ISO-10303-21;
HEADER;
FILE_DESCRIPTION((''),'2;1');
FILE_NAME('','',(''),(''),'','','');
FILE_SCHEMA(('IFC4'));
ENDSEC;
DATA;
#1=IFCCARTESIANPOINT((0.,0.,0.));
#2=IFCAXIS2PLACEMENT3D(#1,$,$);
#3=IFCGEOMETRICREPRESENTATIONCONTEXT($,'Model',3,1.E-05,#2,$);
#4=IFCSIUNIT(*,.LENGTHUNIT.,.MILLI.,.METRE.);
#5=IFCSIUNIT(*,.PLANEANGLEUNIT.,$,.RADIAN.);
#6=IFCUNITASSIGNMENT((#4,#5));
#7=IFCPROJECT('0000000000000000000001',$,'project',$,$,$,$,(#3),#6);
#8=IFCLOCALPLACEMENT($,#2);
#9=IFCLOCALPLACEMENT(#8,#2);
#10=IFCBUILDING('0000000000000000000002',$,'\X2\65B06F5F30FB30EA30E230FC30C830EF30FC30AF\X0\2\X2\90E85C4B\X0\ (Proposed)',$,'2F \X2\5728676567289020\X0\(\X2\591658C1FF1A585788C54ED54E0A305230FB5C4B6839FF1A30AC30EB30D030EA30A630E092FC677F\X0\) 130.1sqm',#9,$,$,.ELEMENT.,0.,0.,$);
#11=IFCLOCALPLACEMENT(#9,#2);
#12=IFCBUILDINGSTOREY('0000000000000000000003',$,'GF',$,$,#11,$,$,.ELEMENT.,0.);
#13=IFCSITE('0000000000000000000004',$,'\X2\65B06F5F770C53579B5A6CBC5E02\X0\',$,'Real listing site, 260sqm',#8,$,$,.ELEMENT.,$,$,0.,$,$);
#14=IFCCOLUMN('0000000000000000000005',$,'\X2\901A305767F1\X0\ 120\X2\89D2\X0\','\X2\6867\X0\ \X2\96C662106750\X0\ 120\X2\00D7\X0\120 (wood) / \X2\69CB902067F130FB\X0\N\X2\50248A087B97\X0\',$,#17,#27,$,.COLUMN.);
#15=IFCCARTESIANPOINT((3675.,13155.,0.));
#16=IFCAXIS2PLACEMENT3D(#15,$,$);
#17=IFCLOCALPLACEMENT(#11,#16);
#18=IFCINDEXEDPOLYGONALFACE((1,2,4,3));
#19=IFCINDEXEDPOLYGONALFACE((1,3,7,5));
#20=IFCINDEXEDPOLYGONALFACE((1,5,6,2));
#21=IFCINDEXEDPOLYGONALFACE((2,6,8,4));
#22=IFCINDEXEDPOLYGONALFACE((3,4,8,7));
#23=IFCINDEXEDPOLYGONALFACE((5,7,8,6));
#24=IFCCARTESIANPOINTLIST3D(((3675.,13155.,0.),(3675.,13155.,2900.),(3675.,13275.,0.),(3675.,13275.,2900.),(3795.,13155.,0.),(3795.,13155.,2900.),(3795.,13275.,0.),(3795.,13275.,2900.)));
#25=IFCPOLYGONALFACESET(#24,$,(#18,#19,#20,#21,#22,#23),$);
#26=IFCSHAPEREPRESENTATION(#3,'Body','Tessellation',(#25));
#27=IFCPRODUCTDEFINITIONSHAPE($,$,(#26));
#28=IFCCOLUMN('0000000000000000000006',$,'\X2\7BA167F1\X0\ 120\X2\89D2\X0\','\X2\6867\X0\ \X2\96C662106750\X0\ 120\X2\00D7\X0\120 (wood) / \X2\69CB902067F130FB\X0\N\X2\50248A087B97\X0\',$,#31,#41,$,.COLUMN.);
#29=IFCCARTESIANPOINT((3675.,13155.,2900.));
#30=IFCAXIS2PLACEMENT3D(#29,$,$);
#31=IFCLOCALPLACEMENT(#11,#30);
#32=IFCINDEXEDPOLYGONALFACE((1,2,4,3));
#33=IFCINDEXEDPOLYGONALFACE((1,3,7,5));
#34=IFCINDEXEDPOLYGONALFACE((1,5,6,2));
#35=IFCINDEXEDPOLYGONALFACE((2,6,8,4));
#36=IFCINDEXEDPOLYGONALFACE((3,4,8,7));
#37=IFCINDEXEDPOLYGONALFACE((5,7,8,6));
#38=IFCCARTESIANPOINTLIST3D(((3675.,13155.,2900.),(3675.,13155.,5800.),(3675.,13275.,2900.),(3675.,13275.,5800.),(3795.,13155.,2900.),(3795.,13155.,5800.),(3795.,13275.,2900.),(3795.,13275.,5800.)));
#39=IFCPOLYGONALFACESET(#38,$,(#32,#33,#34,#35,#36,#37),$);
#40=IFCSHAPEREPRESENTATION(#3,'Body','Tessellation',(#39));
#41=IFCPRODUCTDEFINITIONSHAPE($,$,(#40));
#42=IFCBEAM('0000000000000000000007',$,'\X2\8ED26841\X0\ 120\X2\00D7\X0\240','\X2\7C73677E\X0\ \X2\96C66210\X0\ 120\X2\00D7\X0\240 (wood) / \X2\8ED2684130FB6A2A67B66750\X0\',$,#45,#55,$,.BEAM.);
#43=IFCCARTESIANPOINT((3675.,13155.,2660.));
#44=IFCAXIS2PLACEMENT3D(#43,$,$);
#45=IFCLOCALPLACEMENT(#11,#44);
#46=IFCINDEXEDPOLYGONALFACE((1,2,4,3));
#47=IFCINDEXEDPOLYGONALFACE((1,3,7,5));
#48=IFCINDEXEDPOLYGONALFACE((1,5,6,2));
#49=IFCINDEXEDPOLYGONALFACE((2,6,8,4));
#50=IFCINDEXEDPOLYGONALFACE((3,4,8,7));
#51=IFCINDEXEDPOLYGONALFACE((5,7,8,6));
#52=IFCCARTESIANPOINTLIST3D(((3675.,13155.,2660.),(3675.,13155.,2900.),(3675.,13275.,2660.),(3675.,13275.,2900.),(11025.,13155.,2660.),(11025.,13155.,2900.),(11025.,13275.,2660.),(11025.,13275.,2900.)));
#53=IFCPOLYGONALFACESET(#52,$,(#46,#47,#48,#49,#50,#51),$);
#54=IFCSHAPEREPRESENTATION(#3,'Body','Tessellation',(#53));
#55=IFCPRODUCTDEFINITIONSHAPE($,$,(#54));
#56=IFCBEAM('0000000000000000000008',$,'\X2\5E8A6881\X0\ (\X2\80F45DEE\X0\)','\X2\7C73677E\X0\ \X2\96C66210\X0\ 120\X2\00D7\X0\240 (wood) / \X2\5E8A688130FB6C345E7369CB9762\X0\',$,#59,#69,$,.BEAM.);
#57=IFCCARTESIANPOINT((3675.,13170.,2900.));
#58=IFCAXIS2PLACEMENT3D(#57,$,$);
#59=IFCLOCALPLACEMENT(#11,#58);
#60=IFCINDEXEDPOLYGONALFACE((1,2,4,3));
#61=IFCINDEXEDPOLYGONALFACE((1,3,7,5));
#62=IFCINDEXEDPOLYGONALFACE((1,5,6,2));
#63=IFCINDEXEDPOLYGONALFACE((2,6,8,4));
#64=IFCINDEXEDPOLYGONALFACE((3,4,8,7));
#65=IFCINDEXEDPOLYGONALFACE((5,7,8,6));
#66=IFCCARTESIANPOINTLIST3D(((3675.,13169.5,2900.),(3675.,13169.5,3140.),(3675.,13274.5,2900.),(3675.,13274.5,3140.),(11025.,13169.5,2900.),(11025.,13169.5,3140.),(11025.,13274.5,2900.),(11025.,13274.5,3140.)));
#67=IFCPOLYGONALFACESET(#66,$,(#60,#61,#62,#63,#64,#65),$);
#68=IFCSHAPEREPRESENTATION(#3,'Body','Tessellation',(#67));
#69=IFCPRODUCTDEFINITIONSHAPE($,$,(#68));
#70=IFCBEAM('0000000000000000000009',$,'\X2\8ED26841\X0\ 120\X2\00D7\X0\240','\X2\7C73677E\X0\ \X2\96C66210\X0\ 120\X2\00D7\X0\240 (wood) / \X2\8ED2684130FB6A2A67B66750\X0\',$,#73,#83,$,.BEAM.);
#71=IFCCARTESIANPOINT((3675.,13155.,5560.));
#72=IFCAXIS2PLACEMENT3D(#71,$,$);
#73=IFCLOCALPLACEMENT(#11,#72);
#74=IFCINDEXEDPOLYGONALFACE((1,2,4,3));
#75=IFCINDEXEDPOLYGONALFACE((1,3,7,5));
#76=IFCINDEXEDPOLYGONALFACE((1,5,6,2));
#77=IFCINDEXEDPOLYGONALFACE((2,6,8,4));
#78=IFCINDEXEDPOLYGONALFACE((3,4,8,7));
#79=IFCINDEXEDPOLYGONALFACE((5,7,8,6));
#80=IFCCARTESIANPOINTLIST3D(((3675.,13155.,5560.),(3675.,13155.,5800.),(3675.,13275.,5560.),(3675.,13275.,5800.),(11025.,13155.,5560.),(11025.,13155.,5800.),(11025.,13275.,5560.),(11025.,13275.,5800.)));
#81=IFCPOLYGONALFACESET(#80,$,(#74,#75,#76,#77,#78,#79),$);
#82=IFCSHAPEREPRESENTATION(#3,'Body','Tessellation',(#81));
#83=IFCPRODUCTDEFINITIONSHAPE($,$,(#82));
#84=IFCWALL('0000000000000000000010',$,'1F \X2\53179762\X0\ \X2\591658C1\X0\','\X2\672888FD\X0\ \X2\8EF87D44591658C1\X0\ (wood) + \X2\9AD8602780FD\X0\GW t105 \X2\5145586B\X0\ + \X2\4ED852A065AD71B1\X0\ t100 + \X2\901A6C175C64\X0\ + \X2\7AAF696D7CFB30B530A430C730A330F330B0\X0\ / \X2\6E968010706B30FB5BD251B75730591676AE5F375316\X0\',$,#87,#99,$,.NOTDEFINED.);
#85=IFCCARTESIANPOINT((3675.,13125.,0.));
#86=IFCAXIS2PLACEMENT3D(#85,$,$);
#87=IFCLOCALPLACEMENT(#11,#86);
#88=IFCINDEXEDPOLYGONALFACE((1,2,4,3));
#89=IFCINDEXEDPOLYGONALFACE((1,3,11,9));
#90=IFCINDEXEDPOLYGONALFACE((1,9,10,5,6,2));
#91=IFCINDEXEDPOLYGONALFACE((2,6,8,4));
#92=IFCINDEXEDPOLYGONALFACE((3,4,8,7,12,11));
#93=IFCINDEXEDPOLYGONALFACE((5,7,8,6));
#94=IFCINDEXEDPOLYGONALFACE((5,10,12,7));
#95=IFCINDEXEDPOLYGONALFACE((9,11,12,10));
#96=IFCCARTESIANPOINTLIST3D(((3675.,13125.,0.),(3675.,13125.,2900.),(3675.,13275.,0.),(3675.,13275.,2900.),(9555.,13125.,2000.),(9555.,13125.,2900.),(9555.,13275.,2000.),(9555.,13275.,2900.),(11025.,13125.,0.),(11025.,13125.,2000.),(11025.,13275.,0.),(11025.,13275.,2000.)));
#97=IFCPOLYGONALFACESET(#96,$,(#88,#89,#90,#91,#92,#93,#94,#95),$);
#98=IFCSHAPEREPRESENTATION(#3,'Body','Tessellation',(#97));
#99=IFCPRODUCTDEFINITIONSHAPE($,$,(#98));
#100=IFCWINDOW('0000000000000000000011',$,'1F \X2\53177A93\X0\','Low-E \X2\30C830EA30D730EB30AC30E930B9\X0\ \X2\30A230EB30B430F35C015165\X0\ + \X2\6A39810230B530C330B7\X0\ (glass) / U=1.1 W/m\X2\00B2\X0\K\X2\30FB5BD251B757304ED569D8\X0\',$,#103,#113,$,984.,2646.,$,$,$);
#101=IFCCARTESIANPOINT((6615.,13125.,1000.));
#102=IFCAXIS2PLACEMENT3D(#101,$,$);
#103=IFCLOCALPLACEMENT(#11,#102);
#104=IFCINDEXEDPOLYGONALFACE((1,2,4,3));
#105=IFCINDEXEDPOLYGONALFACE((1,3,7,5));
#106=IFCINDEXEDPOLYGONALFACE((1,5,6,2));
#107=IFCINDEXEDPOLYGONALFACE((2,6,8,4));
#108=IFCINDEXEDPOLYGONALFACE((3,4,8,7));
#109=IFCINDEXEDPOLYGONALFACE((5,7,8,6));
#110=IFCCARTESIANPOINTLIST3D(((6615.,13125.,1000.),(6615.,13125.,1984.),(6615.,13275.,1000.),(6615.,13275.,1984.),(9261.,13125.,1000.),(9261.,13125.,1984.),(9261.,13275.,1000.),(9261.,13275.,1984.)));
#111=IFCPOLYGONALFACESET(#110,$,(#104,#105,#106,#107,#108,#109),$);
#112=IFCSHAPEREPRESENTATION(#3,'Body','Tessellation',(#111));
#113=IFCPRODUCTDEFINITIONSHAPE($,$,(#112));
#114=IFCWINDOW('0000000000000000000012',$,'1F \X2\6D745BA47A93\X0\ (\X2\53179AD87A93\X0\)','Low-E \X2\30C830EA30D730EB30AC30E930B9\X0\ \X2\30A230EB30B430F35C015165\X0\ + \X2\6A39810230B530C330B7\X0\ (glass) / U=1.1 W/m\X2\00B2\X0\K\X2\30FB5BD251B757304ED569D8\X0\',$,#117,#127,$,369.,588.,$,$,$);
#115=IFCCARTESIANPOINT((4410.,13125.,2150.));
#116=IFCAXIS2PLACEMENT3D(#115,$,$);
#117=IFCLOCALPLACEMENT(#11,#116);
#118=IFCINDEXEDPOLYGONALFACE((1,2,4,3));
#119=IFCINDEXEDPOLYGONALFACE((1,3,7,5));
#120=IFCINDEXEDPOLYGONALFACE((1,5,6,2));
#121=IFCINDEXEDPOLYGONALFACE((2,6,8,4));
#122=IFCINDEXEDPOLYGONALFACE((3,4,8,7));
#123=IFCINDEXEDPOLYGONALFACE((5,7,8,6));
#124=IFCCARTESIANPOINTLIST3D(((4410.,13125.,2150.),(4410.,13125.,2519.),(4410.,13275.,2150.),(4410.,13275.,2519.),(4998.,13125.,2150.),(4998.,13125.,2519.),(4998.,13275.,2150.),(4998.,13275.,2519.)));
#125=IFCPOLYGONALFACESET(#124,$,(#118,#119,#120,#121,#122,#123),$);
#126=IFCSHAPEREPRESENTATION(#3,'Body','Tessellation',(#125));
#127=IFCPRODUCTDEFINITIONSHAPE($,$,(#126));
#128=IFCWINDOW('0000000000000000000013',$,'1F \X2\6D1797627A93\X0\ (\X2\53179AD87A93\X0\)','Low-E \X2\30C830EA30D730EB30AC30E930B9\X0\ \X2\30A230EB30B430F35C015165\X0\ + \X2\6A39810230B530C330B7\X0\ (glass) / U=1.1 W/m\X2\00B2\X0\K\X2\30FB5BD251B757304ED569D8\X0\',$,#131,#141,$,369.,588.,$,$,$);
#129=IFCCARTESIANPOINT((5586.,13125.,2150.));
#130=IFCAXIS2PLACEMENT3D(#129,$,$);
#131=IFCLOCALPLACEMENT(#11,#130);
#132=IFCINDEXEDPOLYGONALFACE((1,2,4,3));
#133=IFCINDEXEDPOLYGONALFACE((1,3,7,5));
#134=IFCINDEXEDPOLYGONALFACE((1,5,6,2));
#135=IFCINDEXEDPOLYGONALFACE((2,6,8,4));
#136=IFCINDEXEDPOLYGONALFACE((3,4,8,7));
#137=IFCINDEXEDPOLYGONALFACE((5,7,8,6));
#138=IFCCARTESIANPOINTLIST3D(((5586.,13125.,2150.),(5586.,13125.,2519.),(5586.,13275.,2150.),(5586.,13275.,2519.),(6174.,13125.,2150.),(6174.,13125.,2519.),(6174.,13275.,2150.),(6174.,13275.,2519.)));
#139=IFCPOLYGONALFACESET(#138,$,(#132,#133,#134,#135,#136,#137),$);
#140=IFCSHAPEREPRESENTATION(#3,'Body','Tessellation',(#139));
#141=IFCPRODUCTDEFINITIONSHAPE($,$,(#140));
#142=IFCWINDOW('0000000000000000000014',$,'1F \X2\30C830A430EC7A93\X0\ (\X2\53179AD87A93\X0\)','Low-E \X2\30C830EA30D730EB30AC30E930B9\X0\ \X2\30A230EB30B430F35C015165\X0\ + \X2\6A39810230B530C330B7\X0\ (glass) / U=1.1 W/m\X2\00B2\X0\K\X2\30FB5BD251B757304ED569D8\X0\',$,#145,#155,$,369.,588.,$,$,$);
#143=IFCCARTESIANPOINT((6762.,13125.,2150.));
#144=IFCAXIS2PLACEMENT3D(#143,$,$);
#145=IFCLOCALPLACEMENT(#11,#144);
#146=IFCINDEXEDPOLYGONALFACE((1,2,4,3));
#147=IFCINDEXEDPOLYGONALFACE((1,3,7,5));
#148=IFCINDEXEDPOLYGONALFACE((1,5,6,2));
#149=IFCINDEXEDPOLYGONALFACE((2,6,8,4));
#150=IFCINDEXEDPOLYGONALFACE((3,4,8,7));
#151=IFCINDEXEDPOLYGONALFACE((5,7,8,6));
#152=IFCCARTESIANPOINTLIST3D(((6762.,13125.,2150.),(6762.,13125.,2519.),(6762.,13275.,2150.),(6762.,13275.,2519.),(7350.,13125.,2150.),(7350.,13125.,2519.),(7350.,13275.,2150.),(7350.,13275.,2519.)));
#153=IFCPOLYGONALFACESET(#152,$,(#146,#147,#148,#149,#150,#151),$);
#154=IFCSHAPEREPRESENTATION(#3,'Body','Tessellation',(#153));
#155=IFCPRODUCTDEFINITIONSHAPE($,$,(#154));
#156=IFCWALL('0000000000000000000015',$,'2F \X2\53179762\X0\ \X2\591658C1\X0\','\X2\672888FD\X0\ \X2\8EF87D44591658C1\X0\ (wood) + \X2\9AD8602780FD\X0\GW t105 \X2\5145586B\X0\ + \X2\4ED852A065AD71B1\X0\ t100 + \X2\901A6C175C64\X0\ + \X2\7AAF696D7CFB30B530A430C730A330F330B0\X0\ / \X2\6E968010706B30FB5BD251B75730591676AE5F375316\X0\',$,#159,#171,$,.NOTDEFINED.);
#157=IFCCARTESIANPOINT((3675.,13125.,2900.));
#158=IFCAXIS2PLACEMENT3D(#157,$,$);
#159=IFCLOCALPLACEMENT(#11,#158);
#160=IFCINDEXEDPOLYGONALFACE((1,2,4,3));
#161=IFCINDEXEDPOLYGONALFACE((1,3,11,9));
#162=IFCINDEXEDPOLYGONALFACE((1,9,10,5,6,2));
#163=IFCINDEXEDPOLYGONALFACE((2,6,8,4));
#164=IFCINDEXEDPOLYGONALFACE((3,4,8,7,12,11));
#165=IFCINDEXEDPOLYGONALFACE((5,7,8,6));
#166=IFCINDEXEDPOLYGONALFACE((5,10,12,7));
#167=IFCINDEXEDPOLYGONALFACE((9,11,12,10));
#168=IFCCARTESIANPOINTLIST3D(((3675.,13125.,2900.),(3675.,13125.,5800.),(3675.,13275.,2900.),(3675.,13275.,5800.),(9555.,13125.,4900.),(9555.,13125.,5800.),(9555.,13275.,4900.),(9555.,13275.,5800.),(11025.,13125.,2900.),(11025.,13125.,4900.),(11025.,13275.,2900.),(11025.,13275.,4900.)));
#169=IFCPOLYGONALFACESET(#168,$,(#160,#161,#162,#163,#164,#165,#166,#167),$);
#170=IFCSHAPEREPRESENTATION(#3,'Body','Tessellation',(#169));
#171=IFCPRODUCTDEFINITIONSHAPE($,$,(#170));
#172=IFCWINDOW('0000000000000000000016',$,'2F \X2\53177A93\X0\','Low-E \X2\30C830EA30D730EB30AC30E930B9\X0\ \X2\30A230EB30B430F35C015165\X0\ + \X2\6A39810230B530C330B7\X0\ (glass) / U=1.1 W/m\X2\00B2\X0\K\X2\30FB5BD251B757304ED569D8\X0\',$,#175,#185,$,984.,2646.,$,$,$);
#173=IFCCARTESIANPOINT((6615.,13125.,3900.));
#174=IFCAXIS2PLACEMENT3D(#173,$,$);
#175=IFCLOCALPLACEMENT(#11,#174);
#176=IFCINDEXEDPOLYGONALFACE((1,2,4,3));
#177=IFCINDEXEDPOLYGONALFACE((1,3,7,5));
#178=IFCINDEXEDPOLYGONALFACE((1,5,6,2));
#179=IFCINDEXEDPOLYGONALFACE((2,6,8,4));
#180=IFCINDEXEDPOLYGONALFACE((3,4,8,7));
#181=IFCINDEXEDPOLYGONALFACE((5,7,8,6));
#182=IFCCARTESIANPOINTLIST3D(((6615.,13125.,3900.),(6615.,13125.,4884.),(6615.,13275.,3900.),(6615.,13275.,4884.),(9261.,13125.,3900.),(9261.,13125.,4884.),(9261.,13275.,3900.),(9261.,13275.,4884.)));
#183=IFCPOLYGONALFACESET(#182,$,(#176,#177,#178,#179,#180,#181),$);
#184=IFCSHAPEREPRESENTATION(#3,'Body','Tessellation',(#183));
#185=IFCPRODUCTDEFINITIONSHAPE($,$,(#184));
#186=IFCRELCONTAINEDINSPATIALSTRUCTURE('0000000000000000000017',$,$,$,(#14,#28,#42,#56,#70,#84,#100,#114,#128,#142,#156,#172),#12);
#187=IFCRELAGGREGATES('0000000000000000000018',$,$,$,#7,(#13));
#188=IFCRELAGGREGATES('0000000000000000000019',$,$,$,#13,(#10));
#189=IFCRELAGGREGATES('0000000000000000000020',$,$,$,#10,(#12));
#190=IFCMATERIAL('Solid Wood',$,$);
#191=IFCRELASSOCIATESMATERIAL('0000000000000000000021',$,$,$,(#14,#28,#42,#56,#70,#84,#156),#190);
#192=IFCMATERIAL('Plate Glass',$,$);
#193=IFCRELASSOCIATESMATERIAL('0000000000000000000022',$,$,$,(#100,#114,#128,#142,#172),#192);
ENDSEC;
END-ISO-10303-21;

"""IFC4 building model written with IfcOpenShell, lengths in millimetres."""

from ifc_helpers import new_model, si_unit, frame, frame_2d, origin, place, context, project, spatial, rectangle, extrude, material, element, fill, save


model = new_model("IFC4")

# Units and contexts
model_context = context("Model", 3, precision=1e-05, world=origin())
ifc_project = project(units=[si_unit("LENGTHUNIT", "METRE", prefix="MILLI"), si_unit("PLANEANGLEUNIT", "RADIAN")], contexts=[model_context])

# Site, building, storey
site_placement = place(None, origin())
site = spatial("IfcSite", under=ifc_project, at=site_placement, Name="新潟県南魚沼市", ObjectType="Real listing site, 260sqm", CompositionType="ELEMENT", RefElevation=0.0)
building_placement = place(site_placement, origin())
building = spatial("IfcBuilding", under=site, at=building_placement, Name="新潟・リモートワーク2部屋 (Proposed)", ObjectType="2F 在来木造(外壁：塗装仕上げ・屋根：ガルバリウム鋼板) 130.1sqm", CompositionType="ELEMENT", ElevationOfRefHeight=0.0, ElevationOfTerrain=0.0)
storey_placement = place(building_placement, origin())
storey = spatial("IfcBuildingStorey", under=building, at=storey_placement, Name="GF", CompositionType="ELEMENT", Elevation=0.0)

# Columns
ifc_material_1 = material(Name="Solid Wood")
column_1_placement = place(storey_placement, frame((3675.0, 13155.0, 0.0)))
element("IfcColumn", 1, at=column_1_placement, inside=storey, material=ifc_material_1, Name="通し柱 120角", Description="桧 集成材 120×120 (wood) / 構造柱・N値計算", PredefinedType="COLUMN", context=model_context, shape_type="SweptSolid", body=[
    extrude(rectangle(XDim=120.0, YDim=120.0, at=frame_2d((60.0, 60.0))), frame((3675.0, 13155.0, 0.0)), (0.0, 0.0, 1.0), 2900.0),
])
column_2_placement = place(storey_placement, frame((3675.0, 13155.0, 2900.0)))
element("IfcColumn", 2, at=column_2_placement, inside=storey, material=ifc_material_1, Name="管柱 120角", Description="桧 集成材 120×120 (wood) / 構造柱・N値計算", PredefinedType="COLUMN", context=model_context, shape_type="SweptSolid", body=[
    extrude(rectangle(XDim=120.0, YDim=120.0, at=frame_2d((60.0, 60.0))), frame((3675.0, 13155.0, 2900.0)), (0.0, 0.0, 1.0), 2900.0),
])

# Beams
beam_1_placement = place(storey_placement, frame((3675.0, 13155.0, 2660.0)))
element("IfcBeam", 3, at=beam_1_placement, inside=storey, material=ifc_material_1, Name="軒桁 120×240", Description="米松 集成 120×240 (wood) / 軒桁・横架材", PredefinedType="BEAM", context=model_context, shape_type="SweptSolid", body=[
    extrude(rectangle(XDim=7350.0, YDim=120.0, at=frame_2d((3675.0, 60.0))), frame((3675.0, 13155.0, 2660.0)), (0.0, 0.0, 1.0), 240.0),
])
beam_2_placement = place(storey_placement, frame((3675.0, 13170.0, 2900.0)))
element("IfcBeam", 4, at=beam_2_placement, inside=storey, material=ifc_material_1, Name="床梁 (胴差)", Description="米松 集成 120×240 (wood) / 床梁・水平構面", PredefinedType="BEAM", context=model_context, shape_type="SweptSolid", body=[
    extrude(rectangle(XDim=7350.0, YDim=105.0, at=frame_2d((3675.0, 52.0))), frame((3675.0, 13170.0, 2900.0)), (0.0, 0.0, 1.0), 240.0),
])
beam_3_placement = place(storey_placement, frame((3675.0, 13155.0, 5560.0)))
element("IfcBeam", 5, at=beam_3_placement, inside=storey, material=ifc_material_1, Name="軒桁 120×240", Description="米松 集成 120×240 (wood) / 軒桁・横架材", PredefinedType="BEAM", context=model_context, shape_type="SweptSolid", body=[
    extrude(rectangle(XDim=7350.0, YDim=120.0, at=frame_2d((3675.0, 60.0))), frame((3675.0, 13155.0, 5560.0)), (0.0, 0.0, 1.0), 240.0),
])

# Wall, openings, windows
wall_1_placement = place(storey_placement, frame((3675.0, 13125.0, 0.0)))
wall_1 = element("IfcWall", 6, at=wall_1_placement, inside=storey, material=ifc_material_1, Name="1F 北面 外壁", Description="木製 軸組外壁 (wood) + 高性能GW t105 充填 + 付加断熱 t100 + 通気層 + 窯業系サイディング / 準耐火・寒冷地外皮強化", PredefinedType="NOTDEFINED", context=model_context, shape_type="SweptSolid", body=[
    extrude(rectangle(XDim=7350.0, YDim=150.0, at=frame_2d((3675.0, 75.0))), frame((3675.0, 13125.0, 0.0)), (0.0, 0.0, 1.0), 2900.0),
])
opening_1_placement = place(storey_placement, frame((6615.0, 13125.0, 1000.0)))
opening_1 = element("IfcOpeningElement", 7, at=opening_1_placement, cuts=wall_1, PredefinedType="NOTDEFINED", context=model_context, shape_type="SweptSolid", body=[
    extrude(rectangle(XDim=2646.0, YDim=150.0, at=frame_2d((1323.0, 75.0))), frame((6615.0, 13125.0, 1000.0)), (0.0, 0.0, 1.0), 984.0),
])
opening_2_placement = place(storey_placement, frame((4410.0, 13125.0, 2150.0)))
opening_2 = element("IfcOpeningElement", 8, at=opening_2_placement, cuts=wall_1, PredefinedType="NOTDEFINED", context=model_context, shape_type="SweptSolid", body=[
    extrude(rectangle(XDim=588.0, YDim=150.0, at=frame_2d((294.0, 75.0))), frame((4410.0, 13125.0, 2150.0)), (0.0, 0.0, 1.0), 369.0),
])
opening_3_placement = place(storey_placement, frame((5586.0, 13125.0, 2150.0)))
opening_3 = element("IfcOpeningElement", 9, at=opening_3_placement, cuts=wall_1, PredefinedType="NOTDEFINED", context=model_context, shape_type="SweptSolid", body=[
    extrude(rectangle(XDim=588.0, YDim=150.0, at=frame_2d((294.0, 75.0))), frame((5586.0, 13125.0, 2150.0)), (0.0, 0.0, 1.0), 369.0),
])
opening_4_placement = place(storey_placement, frame((6762.0, 13125.0, 2150.0)))
opening_4 = element("IfcOpeningElement", 10, at=opening_4_placement, cuts=wall_1, PredefinedType="NOTDEFINED", context=model_context, shape_type="SweptSolid", body=[
    extrude(rectangle(XDim=588.0, YDim=150.0, at=frame_2d((294.0, 75.0))), frame((6762.0, 13125.0, 2150.0)), (0.0, 0.0, 1.0), 369.0),
])
ifc_material_2 = material(Name="Plate Glass")
window_1_placement = place(storey_placement, frame((6615.0, 13125.0, 1000.0)))
window_1 = element("IfcWindow", 11, at=window_1_placement, inside=storey, material=ifc_material_2, Name="1F 北窓", Description="Low-E トリプルガラス アルゴン封入 + 樹脂サッシ (glass) / U=1.1 W/m²K・寒冷地仕様", OverallHeight=984.0, OverallWidth=2646.0, context=model_context, shape_type="SweptSolid", body=[
    extrude(rectangle(XDim=2646.0, YDim=150.0, at=frame_2d((1323.0, 75.0))), frame((6615.0, 13125.0, 1000.0)), (0.0, 0.0, 1.0), 984.0),
])
fill(opening_1, window_1)
window_2_placement = place(storey_placement, frame((4410.0, 13125.0, 2150.0)))
window_2 = element("IfcWindow", 12, at=window_2_placement, inside=storey, material=ifc_material_2, Name="1F 浴室窓 (北高窓)", Description="Low-E トリプルガラス アルゴン封入 + 樹脂サッシ (glass) / U=1.1 W/m²K・寒冷地仕様", OverallHeight=369.0, OverallWidth=588.0, context=model_context, shape_type="SweptSolid", body=[
    extrude(rectangle(XDim=588.0, YDim=150.0, at=frame_2d((294.0, 75.0))), frame((4410.0, 13125.0, 2150.0)), (0.0, 0.0, 1.0), 369.0),
])
fill(opening_2, window_2)
window_3_placement = place(storey_placement, frame((5586.0, 13125.0, 2150.0)))
window_3 = element("IfcWindow", 13, at=window_3_placement, inside=storey, material=ifc_material_2, Name="1F 洗面窓 (北高窓)", Description="Low-E トリプルガラス アルゴン封入 + 樹脂サッシ (glass) / U=1.1 W/m²K・寒冷地仕様", OverallHeight=369.0, OverallWidth=588.0, context=model_context, shape_type="SweptSolid", body=[
    extrude(rectangle(XDim=588.0, YDim=150.0, at=frame_2d((294.0, 75.0))), frame((5586.0, 13125.0, 2150.0)), (0.0, 0.0, 1.0), 369.0),
])
fill(opening_3, window_3)
window_4_placement = place(storey_placement, frame((6762.0, 13125.0, 2150.0)))
window_4 = element("IfcWindow", 14, at=window_4_placement, inside=storey, material=ifc_material_2, Name="1F トイレ窓 (北高窓)", Description="Low-E トリプルガラス アルゴン封入 + 樹脂サッシ (glass) / U=1.1 W/m²K・寒冷地仕様", OverallHeight=369.0, OverallWidth=588.0, context=model_context, shape_type="SweptSolid", body=[
    extrude(rectangle(XDim=588.0, YDim=150.0, at=frame_2d((294.0, 75.0))), frame((6762.0, 13125.0, 2150.0)), (0.0, 0.0, 1.0), 369.0),
])
fill(opening_4, window_4)

# Wall, opening, window
wall_2_placement = place(storey_placement, frame((3675.0, 13125.0, 2900.0)))
wall_2 = element("IfcWall", 15, at=wall_2_placement, inside=storey, material=ifc_material_1, Name="2F 北面 外壁", Description="木製 軸組外壁 (wood) + 高性能GW t105 充填 + 付加断熱 t100 + 通気層 + 窯業系サイディング / 準耐火・寒冷地外皮強化", PredefinedType="NOTDEFINED", context=model_context, shape_type="SweptSolid", body=[
    extrude(rectangle(XDim=7350.0, YDim=150.0, at=frame_2d((3675.0, 75.0))), frame((3675.0, 13125.0, 2900.0)), (0.0, 0.0, 1.0), 2900.0),
])
opening_5_placement = place(storey_placement, frame((6615.0, 13125.0, 3900.0)))
opening_5 = element("IfcOpeningElement", 16, at=opening_5_placement, cuts=wall_2, PredefinedType="NOTDEFINED", context=model_context, shape_type="SweptSolid", body=[
    extrude(rectangle(XDim=2646.0, YDim=150.0, at=frame_2d((1323.0, 75.0))), frame((6615.0, 13125.0, 3900.0)), (0.0, 0.0, 1.0), 984.0),
])
window_5_placement = place(storey_placement, frame((6615.0, 13125.0, 3900.0)))
window_5 = element("IfcWindow", 17, at=window_5_placement, inside=storey, material=ifc_material_2, Name="2F 北窓", Description="Low-E トリプルガラス アルゴン封入 + 樹脂サッシ (glass) / U=1.1 W/m²K・寒冷地仕様", OverallHeight=984.0, OverallWidth=2646.0, context=model_context, shape_type="SweptSolid", body=[
    extrude(rectangle(XDim=2646.0, YDim=150.0, at=frame_2d((1323.0, 75.0))), frame((6615.0, 13125.0, 3900.0)), (0.0, 0.0, 1.0), 984.0),
])
fill(opening_5, window_5)

save(model, "model.ifc")
